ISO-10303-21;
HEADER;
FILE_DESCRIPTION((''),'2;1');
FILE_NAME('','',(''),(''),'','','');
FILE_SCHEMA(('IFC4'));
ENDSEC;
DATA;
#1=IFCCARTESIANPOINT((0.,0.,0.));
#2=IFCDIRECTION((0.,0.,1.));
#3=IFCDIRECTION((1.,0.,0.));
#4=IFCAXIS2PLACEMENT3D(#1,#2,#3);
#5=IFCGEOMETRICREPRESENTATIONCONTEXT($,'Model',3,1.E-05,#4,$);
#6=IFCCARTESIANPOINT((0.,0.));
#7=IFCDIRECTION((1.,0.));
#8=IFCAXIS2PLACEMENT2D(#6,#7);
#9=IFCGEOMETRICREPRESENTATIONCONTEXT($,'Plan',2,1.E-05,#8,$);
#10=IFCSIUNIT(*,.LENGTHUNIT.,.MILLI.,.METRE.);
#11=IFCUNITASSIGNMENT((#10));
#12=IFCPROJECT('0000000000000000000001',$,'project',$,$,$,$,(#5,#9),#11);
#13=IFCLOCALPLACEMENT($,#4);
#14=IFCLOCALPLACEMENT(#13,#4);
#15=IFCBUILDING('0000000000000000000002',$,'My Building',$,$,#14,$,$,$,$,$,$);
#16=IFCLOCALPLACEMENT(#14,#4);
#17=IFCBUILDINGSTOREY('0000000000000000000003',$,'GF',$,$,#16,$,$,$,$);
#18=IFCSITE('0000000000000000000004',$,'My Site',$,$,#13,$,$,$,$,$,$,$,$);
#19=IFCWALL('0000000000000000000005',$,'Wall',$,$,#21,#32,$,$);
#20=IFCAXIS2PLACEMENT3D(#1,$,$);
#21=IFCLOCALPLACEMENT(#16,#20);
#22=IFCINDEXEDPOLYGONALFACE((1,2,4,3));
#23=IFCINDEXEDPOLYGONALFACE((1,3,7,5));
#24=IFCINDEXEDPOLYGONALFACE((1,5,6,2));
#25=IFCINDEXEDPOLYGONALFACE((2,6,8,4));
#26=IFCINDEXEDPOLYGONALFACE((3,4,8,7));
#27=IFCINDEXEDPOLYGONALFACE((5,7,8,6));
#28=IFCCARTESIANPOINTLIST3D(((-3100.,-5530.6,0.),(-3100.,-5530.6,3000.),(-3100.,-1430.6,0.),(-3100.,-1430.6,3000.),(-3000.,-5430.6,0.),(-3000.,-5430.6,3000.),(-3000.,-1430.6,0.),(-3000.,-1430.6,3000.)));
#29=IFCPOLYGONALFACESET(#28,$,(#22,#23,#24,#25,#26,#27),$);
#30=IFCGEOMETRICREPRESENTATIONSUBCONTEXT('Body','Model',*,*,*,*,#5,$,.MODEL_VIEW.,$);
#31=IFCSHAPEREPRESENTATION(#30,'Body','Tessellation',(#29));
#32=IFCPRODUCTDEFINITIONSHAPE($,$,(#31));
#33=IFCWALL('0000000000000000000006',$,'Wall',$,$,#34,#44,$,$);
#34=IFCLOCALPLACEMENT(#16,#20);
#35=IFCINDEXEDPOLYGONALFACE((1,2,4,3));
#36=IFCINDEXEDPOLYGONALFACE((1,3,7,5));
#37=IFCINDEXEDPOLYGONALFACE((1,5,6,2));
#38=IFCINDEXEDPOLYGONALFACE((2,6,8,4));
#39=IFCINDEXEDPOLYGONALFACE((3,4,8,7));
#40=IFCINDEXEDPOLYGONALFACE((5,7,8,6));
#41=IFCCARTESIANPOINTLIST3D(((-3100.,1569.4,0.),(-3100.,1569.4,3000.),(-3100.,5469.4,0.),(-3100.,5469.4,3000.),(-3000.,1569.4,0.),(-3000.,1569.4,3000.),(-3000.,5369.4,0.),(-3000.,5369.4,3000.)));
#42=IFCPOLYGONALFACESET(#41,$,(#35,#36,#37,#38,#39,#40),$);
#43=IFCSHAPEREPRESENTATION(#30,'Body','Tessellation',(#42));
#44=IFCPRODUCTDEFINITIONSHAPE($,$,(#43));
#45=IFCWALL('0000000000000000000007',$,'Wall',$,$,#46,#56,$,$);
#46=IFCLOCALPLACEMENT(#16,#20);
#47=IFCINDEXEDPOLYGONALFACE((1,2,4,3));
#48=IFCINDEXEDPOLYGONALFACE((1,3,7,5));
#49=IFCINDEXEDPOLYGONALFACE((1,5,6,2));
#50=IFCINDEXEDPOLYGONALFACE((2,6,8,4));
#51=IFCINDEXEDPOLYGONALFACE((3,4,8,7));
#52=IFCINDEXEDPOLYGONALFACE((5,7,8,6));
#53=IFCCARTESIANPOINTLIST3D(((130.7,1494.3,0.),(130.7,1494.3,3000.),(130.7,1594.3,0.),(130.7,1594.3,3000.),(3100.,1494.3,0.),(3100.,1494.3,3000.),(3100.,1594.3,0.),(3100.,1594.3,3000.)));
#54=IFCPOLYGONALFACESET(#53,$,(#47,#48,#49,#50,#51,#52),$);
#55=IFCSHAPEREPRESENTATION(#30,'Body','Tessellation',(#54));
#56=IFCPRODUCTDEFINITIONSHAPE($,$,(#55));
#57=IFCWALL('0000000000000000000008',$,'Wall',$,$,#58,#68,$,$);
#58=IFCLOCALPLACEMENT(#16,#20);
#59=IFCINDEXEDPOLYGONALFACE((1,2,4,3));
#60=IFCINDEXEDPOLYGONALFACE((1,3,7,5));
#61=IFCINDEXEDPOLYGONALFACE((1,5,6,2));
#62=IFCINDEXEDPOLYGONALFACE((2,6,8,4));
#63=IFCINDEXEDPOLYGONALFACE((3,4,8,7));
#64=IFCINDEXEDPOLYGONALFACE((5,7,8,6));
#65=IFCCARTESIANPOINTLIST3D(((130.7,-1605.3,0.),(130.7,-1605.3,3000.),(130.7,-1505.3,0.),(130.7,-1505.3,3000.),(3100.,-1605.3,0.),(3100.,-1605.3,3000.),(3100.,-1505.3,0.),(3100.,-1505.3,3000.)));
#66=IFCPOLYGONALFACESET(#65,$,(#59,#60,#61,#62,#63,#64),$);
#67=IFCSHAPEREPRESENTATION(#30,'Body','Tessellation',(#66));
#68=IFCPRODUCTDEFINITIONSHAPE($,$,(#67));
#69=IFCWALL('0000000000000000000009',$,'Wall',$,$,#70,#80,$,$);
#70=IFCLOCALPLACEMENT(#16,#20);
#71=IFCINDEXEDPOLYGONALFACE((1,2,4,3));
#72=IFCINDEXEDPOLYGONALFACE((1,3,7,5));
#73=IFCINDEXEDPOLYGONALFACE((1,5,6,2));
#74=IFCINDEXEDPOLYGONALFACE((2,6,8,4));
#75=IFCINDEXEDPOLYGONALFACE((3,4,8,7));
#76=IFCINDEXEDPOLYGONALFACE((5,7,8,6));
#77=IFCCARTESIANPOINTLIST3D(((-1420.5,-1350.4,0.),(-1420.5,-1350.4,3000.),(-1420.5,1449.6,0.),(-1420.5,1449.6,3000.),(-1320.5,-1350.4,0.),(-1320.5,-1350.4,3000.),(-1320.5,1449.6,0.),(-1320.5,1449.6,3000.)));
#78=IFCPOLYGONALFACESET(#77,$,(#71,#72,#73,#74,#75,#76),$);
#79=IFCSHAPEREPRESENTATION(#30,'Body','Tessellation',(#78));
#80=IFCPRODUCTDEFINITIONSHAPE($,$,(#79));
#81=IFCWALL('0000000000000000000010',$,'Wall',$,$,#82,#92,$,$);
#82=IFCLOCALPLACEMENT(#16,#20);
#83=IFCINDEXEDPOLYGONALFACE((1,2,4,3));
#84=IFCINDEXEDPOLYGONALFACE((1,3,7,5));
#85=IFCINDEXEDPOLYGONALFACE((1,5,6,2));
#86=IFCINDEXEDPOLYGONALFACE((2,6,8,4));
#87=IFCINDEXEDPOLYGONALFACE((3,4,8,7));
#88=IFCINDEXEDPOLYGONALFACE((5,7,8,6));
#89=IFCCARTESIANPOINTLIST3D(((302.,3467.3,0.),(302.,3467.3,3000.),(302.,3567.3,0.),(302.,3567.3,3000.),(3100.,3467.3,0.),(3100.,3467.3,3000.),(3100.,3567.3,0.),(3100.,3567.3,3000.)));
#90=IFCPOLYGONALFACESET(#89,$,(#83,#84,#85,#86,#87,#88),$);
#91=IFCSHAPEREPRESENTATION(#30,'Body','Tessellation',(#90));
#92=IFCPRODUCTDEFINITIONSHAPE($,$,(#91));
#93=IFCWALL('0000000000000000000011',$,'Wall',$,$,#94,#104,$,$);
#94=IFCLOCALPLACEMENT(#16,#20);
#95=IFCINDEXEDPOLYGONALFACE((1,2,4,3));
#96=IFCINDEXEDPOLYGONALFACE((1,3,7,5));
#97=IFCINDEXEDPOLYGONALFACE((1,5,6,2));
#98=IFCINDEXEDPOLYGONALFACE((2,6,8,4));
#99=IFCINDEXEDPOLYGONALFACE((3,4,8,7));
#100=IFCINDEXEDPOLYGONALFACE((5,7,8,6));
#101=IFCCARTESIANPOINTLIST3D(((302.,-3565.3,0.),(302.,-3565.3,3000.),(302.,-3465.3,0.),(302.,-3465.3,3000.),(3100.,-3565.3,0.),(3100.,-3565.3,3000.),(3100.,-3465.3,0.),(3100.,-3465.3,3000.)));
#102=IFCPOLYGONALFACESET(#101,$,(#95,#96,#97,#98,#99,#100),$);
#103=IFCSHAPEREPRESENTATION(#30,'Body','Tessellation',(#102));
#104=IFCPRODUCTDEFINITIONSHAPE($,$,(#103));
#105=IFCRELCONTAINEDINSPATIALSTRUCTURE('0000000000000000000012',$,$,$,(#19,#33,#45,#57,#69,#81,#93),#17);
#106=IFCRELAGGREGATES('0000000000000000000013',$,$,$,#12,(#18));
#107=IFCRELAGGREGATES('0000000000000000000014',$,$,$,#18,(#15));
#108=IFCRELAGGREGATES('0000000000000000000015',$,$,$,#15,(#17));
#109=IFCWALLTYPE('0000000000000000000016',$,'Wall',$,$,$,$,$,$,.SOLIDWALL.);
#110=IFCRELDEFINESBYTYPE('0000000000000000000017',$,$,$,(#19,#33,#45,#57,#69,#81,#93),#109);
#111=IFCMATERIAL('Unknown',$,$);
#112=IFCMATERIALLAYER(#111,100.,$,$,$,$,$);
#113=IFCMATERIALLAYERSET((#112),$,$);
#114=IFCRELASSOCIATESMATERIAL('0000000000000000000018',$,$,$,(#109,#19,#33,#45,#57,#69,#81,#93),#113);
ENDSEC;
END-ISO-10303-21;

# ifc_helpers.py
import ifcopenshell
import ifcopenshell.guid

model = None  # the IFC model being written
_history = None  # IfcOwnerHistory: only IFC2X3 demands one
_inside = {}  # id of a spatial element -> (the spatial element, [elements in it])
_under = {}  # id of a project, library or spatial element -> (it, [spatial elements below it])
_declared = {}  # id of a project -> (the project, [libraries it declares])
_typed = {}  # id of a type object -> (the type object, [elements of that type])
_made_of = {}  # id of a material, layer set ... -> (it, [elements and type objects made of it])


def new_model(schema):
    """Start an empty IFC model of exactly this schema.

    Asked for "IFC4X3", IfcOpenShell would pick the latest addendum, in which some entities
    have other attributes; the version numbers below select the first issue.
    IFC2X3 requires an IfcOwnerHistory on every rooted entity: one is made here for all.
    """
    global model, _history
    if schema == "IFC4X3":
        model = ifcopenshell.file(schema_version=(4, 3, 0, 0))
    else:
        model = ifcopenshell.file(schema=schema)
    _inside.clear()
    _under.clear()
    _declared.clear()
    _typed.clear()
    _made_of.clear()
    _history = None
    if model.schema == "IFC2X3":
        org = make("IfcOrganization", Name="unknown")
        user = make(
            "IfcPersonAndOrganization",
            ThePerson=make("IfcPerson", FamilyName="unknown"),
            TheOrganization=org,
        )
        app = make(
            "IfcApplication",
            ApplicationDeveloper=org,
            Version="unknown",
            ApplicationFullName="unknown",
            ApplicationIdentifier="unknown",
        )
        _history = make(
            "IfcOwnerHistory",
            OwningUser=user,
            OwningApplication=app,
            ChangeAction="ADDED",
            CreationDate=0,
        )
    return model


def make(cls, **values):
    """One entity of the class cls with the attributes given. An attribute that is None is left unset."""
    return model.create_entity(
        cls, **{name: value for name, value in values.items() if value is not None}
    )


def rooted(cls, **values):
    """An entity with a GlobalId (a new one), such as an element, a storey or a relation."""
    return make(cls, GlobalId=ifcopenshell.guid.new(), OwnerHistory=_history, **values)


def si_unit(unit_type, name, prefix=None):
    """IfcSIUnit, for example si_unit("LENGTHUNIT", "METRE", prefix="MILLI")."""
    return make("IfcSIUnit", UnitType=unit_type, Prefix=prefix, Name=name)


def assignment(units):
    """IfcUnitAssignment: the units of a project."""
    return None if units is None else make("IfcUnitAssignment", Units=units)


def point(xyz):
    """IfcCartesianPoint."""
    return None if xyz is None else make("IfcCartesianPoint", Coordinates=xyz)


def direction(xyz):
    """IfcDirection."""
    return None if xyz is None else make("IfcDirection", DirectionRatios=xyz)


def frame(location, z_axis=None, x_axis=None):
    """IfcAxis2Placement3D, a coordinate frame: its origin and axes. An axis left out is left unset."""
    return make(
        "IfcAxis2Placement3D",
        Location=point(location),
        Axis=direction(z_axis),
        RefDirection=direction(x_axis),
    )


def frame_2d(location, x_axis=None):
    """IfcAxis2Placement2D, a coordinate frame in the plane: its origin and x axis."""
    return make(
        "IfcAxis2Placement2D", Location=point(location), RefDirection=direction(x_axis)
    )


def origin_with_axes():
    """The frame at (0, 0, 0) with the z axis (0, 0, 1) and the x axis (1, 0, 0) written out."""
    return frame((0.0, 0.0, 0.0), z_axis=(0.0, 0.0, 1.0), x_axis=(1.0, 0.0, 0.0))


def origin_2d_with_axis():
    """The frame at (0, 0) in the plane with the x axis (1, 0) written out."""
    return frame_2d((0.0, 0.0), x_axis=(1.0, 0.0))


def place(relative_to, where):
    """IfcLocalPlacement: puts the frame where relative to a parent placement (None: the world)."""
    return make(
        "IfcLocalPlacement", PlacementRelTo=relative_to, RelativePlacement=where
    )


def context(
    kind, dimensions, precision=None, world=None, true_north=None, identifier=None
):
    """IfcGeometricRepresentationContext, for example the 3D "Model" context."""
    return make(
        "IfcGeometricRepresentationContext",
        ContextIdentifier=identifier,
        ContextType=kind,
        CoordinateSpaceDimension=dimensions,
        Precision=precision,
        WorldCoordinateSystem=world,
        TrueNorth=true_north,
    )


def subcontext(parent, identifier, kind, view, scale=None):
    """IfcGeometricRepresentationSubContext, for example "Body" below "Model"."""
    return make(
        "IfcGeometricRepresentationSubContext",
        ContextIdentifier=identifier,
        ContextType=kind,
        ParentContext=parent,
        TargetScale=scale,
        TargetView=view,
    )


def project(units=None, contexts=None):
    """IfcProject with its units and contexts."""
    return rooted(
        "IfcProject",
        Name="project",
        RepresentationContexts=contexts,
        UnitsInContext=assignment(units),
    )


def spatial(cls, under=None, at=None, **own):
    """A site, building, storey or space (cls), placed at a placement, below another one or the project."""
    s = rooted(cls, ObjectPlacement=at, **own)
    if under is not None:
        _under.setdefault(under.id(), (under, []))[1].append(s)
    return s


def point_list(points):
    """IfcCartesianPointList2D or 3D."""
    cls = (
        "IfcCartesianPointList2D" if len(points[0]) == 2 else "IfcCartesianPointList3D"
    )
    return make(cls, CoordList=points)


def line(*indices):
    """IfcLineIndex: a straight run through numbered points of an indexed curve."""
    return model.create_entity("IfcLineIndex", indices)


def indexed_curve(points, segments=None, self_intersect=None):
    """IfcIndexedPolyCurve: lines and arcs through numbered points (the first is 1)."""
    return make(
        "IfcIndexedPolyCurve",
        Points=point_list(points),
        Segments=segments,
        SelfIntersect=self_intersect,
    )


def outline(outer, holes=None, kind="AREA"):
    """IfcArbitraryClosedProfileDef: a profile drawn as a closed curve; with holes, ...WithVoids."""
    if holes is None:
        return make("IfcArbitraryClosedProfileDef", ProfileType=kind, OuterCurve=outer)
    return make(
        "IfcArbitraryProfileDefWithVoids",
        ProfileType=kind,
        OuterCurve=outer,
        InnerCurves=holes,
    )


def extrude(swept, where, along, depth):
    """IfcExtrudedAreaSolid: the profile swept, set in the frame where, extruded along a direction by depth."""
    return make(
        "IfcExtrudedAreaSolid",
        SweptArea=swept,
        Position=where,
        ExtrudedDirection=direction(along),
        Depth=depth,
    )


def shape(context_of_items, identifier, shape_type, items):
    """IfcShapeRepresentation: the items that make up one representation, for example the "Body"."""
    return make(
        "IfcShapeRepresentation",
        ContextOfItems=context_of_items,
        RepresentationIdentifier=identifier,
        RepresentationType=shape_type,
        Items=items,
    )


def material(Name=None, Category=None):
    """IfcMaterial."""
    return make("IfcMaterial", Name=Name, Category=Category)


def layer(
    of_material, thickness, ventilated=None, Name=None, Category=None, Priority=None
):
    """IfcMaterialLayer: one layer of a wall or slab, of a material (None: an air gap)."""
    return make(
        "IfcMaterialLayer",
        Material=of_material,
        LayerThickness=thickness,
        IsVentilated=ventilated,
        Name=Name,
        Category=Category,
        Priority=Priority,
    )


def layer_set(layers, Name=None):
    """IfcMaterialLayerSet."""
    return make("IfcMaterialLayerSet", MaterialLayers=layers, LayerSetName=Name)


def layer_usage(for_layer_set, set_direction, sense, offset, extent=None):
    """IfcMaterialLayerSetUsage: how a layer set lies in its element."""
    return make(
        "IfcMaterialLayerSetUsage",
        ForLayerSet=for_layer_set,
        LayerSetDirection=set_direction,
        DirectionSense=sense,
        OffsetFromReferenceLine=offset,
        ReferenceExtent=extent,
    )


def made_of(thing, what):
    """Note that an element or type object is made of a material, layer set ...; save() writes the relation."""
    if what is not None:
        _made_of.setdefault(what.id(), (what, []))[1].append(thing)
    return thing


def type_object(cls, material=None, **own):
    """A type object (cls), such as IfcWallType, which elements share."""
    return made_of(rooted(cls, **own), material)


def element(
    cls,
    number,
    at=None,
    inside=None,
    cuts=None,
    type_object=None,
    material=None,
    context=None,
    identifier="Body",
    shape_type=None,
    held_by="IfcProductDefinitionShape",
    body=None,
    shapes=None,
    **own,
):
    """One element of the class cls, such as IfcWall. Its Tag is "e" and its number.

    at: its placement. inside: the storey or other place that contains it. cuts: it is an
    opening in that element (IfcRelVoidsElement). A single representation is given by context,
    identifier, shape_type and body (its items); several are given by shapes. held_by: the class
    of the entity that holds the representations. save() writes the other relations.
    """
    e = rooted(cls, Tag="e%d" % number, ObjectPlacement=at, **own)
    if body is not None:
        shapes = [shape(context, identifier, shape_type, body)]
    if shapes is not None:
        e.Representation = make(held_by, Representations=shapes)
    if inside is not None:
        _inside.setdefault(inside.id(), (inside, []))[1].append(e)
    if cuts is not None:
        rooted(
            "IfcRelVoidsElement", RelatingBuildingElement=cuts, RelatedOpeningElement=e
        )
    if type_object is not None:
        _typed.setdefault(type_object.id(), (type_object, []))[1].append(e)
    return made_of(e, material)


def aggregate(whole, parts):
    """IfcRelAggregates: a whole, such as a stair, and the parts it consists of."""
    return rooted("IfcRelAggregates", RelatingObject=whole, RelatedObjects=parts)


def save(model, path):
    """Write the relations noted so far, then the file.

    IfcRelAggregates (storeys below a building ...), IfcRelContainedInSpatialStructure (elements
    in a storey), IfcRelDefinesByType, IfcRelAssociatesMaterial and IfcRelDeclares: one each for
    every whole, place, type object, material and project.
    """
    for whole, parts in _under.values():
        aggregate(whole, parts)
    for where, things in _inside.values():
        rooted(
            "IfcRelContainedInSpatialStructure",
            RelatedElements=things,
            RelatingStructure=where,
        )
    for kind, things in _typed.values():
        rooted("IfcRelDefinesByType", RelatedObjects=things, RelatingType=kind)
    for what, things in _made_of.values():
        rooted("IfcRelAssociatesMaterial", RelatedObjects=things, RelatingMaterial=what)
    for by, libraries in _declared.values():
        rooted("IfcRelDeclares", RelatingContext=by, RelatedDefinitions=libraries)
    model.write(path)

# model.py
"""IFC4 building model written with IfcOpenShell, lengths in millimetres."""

from ifc_helpers import new_model, si_unit, frame, origin_with_axes, origin_2d_with_axis, place, context, subcontext, project, spatial, line, indexed_curve, outline, extrude, material, layer, layer_set, layer_usage, type_object, element, save


model = new_model("IFC4")

# Units and contexts
model_context = context("Model", 3, precision=1e-05, world=origin_with_axes())
plan_context = context("Plan", 2, precision=1e-05, world=origin_2d_with_axis())
body_context_1 = subcontext(model_context, "Body", "Model", "MODEL_VIEW")
ifc_project = project(units=[si_unit("LENGTHUNIT", "METRE", prefix="MILLI")], contexts=[model_context, plan_context])

# Site, building, storey
site_placement = place(None, origin_with_axes())
site = spatial("IfcSite", under=ifc_project, at=site_placement, Name="My Site")
building_placement = place(site_placement, origin_with_axes())
building = spatial("IfcBuilding", under=site, at=building_placement, Name="My Building")
storey_placement = place(building_placement, origin_with_axes())
storey = spatial("IfcBuildingStorey", under=building, at=storey_placement, Name="GF")

# Shared definitions
ifc_material = material(Name="Unknown")

# Shared definitions
ifc_layer_1 = layer(ifc_material, 100.0)
ifc_layer_set_1 = layer_set([ifc_layer_1])
wall_type = type_object("IfcWallType", Name="Wall", PredefinedType="SOLIDWALL", material=ifc_layer_set_1)

# Walls
ifc_layer_usage_1 = layer_usage(ifc_layer_set_1, "AXIS2", "POSITIVE", 0.0)
wall_1_placement = place(storey_placement, frame((-3000.0, -5430.6, 0.0), z_axis=(0.0, 0.0, 1.0), x_axis=(0.0, 1.0, 0.0)))
element("IfcWall", 1, at=wall_1_placement, inside=storey, type_object=wall_type, material=ifc_layer_usage_1, Name="Wall", context=body_context_1, shape_type="SweptSolid", body=[
    extrude(outline(indexed_curve([(0.0, 0.0), (-100.0, 100.0), (4000.0, 100.0), (4000.0, 0.0)], segments=[line(1, 2, 3, 4, 1)])), origin_with_axes(), (0.0, 0.0, 1.0), 3000.0),
])
ifc_layer_usage_2 = layer_usage(ifc_layer_set_1, "AXIS2", "POSITIVE", 0.0)
wall_2_placement = place(storey_placement, frame((-3100.0, 5369.4, 0.0), z_axis=(0.0, 0.0, 1.0), x_axis=(0.0, -1.0, 0.0)))
element("IfcWall", 2, at=wall_2_placement, inside=storey, type_object=wall_type, material=ifc_layer_usage_2, Name="Wall", context=body_context_1, shape_type="SweptSolid", body=[
    extrude(outline(indexed_curve([(-100.0, 0.0), (0.0, 100.0), (3800.0, 100.0), (3800.0, 0.0)], segments=[line(1, 2, 3, 4, 1)])), origin_with_axes(), (0.0, 0.0, 1.0), 3000.0),
])
ifc_layer_usage_3 = layer_usage(ifc_layer_set_1, "AXIS2", "POSITIVE", 0.0)
wall_3_placement = place(storey_placement, frame((130.7, 1494.3, 0.0), z_axis=(0.0, 0.0, 1.0), x_axis=(1.0, 0.0, 0.0)))
element("IfcWall", 3, at=wall_3_placement, inside=storey, type_object=wall_type, material=ifc_layer_usage_3, Name="Wall", context=body_context_1, shape_type="SweptSolid", body=[
    extrude(outline(indexed_curve([(0.0, 0.0), (0.0, 100.0), (2969.3, 100.0), (2969.3, 0.0)], segments=[line(1, 2, 3, 4, 1)])), origin_with_axes(), (0.0, 0.0, 1.0), 3000.0),
])
ifc_layer_usage_4 = layer_usage(ifc_layer_set_1, "AXIS2", "POSITIVE", 0.0)
wall_4_placement = place(storey_placement, frame((130.7, -1605.3, 0.0), z_axis=(0.0, 0.0, 1.0), x_axis=(1.0, 0.0, 0.0)))
element("IfcWall", 4, at=wall_4_placement, inside=storey, type_object=wall_type, material=ifc_layer_usage_4, Name="Wall", context=body_context_1, shape_type="SweptSolid", body=[
    extrude(outline(indexed_curve([(0.0, 0.0), (0.0, 100.0), (2969.3, 100.0), (2969.3, 0.0)], segments=[line(1, 2, 3, 4, 1)])), origin_with_axes(), (0.0, 0.0, 1.0), 3000.0),
])

# Walls
ifc_layer_usage_5 = layer_usage(ifc_layer_set_1, "AXIS2", "POSITIVE", 0.0)
wall_5_placement = place(storey_placement, frame((-1420.5, 1449.6, 0.0), z_axis=(0.0, 0.0, 1.0), x_axis=(0.0, -1.0, 0.0)))
element("IfcWall", 5, at=wall_5_placement, inside=storey, type_object=wall_type, material=ifc_layer_usage_5, Name="Wall", context=body_context_1, shape_type="SweptSolid", body=[
    extrude(outline(indexed_curve([(0.0, 0.0), (0.0, 100.0), (2800.0, 100.0), (2800.0, 0.0)], segments=[line(1, 2, 3, 4, 1)])), origin_with_axes(), (0.0, 0.0, 1.0), 3000.0),
])
ifc_layer_usage_6 = layer_usage(ifc_layer_set_1, "AXIS2", "POSITIVE", 0.0)
wall_6_placement = place(storey_placement, frame((302.0, 3467.3, 0.0), z_axis=(0.0, 0.0, 1.0), x_axis=(1.0, 0.0, 0.0)))
element("IfcWall", 6, at=wall_6_placement, inside=storey, type_object=wall_type, material=ifc_layer_usage_6, Name="Wall", context=body_context_1, shape_type="SweptSolid", body=[
    extrude(outline(indexed_curve([(0.0, 0.0), (0.0, 100.0), (2798.0, 100.0), (2798.0, 0.0)], segments=[line(1, 2, 3, 4, 1)])), origin_with_axes(), (0.0, 0.0, 1.0), 3000.0),
])
ifc_layer_usage_7 = layer_usage(ifc_layer_set_1, "AXIS2", "POSITIVE", 0.0)
wall_7_placement = place(storey_placement, frame((302.0, -3565.3, 0.0), z_axis=(0.0, 0.0, 1.0), x_axis=(1.0, 0.0, 0.0)))
element("IfcWall", 7, at=wall_7_placement, inside=storey, type_object=wall_type, material=ifc_layer_usage_7, Name="Wall", context=body_context_1, shape_type="SweptSolid", body=[
    extrude(outline(indexed_curve([(0.0, 0.0), (0.0, 100.0), (2798.0, 100.0), (2798.0, 0.0)], segments=[line(1, 2, 3, 4, 1)])), origin_with_axes(), (0.0, 0.0, 1.0), 3000.0),
])

save(model, "model.ifc")
